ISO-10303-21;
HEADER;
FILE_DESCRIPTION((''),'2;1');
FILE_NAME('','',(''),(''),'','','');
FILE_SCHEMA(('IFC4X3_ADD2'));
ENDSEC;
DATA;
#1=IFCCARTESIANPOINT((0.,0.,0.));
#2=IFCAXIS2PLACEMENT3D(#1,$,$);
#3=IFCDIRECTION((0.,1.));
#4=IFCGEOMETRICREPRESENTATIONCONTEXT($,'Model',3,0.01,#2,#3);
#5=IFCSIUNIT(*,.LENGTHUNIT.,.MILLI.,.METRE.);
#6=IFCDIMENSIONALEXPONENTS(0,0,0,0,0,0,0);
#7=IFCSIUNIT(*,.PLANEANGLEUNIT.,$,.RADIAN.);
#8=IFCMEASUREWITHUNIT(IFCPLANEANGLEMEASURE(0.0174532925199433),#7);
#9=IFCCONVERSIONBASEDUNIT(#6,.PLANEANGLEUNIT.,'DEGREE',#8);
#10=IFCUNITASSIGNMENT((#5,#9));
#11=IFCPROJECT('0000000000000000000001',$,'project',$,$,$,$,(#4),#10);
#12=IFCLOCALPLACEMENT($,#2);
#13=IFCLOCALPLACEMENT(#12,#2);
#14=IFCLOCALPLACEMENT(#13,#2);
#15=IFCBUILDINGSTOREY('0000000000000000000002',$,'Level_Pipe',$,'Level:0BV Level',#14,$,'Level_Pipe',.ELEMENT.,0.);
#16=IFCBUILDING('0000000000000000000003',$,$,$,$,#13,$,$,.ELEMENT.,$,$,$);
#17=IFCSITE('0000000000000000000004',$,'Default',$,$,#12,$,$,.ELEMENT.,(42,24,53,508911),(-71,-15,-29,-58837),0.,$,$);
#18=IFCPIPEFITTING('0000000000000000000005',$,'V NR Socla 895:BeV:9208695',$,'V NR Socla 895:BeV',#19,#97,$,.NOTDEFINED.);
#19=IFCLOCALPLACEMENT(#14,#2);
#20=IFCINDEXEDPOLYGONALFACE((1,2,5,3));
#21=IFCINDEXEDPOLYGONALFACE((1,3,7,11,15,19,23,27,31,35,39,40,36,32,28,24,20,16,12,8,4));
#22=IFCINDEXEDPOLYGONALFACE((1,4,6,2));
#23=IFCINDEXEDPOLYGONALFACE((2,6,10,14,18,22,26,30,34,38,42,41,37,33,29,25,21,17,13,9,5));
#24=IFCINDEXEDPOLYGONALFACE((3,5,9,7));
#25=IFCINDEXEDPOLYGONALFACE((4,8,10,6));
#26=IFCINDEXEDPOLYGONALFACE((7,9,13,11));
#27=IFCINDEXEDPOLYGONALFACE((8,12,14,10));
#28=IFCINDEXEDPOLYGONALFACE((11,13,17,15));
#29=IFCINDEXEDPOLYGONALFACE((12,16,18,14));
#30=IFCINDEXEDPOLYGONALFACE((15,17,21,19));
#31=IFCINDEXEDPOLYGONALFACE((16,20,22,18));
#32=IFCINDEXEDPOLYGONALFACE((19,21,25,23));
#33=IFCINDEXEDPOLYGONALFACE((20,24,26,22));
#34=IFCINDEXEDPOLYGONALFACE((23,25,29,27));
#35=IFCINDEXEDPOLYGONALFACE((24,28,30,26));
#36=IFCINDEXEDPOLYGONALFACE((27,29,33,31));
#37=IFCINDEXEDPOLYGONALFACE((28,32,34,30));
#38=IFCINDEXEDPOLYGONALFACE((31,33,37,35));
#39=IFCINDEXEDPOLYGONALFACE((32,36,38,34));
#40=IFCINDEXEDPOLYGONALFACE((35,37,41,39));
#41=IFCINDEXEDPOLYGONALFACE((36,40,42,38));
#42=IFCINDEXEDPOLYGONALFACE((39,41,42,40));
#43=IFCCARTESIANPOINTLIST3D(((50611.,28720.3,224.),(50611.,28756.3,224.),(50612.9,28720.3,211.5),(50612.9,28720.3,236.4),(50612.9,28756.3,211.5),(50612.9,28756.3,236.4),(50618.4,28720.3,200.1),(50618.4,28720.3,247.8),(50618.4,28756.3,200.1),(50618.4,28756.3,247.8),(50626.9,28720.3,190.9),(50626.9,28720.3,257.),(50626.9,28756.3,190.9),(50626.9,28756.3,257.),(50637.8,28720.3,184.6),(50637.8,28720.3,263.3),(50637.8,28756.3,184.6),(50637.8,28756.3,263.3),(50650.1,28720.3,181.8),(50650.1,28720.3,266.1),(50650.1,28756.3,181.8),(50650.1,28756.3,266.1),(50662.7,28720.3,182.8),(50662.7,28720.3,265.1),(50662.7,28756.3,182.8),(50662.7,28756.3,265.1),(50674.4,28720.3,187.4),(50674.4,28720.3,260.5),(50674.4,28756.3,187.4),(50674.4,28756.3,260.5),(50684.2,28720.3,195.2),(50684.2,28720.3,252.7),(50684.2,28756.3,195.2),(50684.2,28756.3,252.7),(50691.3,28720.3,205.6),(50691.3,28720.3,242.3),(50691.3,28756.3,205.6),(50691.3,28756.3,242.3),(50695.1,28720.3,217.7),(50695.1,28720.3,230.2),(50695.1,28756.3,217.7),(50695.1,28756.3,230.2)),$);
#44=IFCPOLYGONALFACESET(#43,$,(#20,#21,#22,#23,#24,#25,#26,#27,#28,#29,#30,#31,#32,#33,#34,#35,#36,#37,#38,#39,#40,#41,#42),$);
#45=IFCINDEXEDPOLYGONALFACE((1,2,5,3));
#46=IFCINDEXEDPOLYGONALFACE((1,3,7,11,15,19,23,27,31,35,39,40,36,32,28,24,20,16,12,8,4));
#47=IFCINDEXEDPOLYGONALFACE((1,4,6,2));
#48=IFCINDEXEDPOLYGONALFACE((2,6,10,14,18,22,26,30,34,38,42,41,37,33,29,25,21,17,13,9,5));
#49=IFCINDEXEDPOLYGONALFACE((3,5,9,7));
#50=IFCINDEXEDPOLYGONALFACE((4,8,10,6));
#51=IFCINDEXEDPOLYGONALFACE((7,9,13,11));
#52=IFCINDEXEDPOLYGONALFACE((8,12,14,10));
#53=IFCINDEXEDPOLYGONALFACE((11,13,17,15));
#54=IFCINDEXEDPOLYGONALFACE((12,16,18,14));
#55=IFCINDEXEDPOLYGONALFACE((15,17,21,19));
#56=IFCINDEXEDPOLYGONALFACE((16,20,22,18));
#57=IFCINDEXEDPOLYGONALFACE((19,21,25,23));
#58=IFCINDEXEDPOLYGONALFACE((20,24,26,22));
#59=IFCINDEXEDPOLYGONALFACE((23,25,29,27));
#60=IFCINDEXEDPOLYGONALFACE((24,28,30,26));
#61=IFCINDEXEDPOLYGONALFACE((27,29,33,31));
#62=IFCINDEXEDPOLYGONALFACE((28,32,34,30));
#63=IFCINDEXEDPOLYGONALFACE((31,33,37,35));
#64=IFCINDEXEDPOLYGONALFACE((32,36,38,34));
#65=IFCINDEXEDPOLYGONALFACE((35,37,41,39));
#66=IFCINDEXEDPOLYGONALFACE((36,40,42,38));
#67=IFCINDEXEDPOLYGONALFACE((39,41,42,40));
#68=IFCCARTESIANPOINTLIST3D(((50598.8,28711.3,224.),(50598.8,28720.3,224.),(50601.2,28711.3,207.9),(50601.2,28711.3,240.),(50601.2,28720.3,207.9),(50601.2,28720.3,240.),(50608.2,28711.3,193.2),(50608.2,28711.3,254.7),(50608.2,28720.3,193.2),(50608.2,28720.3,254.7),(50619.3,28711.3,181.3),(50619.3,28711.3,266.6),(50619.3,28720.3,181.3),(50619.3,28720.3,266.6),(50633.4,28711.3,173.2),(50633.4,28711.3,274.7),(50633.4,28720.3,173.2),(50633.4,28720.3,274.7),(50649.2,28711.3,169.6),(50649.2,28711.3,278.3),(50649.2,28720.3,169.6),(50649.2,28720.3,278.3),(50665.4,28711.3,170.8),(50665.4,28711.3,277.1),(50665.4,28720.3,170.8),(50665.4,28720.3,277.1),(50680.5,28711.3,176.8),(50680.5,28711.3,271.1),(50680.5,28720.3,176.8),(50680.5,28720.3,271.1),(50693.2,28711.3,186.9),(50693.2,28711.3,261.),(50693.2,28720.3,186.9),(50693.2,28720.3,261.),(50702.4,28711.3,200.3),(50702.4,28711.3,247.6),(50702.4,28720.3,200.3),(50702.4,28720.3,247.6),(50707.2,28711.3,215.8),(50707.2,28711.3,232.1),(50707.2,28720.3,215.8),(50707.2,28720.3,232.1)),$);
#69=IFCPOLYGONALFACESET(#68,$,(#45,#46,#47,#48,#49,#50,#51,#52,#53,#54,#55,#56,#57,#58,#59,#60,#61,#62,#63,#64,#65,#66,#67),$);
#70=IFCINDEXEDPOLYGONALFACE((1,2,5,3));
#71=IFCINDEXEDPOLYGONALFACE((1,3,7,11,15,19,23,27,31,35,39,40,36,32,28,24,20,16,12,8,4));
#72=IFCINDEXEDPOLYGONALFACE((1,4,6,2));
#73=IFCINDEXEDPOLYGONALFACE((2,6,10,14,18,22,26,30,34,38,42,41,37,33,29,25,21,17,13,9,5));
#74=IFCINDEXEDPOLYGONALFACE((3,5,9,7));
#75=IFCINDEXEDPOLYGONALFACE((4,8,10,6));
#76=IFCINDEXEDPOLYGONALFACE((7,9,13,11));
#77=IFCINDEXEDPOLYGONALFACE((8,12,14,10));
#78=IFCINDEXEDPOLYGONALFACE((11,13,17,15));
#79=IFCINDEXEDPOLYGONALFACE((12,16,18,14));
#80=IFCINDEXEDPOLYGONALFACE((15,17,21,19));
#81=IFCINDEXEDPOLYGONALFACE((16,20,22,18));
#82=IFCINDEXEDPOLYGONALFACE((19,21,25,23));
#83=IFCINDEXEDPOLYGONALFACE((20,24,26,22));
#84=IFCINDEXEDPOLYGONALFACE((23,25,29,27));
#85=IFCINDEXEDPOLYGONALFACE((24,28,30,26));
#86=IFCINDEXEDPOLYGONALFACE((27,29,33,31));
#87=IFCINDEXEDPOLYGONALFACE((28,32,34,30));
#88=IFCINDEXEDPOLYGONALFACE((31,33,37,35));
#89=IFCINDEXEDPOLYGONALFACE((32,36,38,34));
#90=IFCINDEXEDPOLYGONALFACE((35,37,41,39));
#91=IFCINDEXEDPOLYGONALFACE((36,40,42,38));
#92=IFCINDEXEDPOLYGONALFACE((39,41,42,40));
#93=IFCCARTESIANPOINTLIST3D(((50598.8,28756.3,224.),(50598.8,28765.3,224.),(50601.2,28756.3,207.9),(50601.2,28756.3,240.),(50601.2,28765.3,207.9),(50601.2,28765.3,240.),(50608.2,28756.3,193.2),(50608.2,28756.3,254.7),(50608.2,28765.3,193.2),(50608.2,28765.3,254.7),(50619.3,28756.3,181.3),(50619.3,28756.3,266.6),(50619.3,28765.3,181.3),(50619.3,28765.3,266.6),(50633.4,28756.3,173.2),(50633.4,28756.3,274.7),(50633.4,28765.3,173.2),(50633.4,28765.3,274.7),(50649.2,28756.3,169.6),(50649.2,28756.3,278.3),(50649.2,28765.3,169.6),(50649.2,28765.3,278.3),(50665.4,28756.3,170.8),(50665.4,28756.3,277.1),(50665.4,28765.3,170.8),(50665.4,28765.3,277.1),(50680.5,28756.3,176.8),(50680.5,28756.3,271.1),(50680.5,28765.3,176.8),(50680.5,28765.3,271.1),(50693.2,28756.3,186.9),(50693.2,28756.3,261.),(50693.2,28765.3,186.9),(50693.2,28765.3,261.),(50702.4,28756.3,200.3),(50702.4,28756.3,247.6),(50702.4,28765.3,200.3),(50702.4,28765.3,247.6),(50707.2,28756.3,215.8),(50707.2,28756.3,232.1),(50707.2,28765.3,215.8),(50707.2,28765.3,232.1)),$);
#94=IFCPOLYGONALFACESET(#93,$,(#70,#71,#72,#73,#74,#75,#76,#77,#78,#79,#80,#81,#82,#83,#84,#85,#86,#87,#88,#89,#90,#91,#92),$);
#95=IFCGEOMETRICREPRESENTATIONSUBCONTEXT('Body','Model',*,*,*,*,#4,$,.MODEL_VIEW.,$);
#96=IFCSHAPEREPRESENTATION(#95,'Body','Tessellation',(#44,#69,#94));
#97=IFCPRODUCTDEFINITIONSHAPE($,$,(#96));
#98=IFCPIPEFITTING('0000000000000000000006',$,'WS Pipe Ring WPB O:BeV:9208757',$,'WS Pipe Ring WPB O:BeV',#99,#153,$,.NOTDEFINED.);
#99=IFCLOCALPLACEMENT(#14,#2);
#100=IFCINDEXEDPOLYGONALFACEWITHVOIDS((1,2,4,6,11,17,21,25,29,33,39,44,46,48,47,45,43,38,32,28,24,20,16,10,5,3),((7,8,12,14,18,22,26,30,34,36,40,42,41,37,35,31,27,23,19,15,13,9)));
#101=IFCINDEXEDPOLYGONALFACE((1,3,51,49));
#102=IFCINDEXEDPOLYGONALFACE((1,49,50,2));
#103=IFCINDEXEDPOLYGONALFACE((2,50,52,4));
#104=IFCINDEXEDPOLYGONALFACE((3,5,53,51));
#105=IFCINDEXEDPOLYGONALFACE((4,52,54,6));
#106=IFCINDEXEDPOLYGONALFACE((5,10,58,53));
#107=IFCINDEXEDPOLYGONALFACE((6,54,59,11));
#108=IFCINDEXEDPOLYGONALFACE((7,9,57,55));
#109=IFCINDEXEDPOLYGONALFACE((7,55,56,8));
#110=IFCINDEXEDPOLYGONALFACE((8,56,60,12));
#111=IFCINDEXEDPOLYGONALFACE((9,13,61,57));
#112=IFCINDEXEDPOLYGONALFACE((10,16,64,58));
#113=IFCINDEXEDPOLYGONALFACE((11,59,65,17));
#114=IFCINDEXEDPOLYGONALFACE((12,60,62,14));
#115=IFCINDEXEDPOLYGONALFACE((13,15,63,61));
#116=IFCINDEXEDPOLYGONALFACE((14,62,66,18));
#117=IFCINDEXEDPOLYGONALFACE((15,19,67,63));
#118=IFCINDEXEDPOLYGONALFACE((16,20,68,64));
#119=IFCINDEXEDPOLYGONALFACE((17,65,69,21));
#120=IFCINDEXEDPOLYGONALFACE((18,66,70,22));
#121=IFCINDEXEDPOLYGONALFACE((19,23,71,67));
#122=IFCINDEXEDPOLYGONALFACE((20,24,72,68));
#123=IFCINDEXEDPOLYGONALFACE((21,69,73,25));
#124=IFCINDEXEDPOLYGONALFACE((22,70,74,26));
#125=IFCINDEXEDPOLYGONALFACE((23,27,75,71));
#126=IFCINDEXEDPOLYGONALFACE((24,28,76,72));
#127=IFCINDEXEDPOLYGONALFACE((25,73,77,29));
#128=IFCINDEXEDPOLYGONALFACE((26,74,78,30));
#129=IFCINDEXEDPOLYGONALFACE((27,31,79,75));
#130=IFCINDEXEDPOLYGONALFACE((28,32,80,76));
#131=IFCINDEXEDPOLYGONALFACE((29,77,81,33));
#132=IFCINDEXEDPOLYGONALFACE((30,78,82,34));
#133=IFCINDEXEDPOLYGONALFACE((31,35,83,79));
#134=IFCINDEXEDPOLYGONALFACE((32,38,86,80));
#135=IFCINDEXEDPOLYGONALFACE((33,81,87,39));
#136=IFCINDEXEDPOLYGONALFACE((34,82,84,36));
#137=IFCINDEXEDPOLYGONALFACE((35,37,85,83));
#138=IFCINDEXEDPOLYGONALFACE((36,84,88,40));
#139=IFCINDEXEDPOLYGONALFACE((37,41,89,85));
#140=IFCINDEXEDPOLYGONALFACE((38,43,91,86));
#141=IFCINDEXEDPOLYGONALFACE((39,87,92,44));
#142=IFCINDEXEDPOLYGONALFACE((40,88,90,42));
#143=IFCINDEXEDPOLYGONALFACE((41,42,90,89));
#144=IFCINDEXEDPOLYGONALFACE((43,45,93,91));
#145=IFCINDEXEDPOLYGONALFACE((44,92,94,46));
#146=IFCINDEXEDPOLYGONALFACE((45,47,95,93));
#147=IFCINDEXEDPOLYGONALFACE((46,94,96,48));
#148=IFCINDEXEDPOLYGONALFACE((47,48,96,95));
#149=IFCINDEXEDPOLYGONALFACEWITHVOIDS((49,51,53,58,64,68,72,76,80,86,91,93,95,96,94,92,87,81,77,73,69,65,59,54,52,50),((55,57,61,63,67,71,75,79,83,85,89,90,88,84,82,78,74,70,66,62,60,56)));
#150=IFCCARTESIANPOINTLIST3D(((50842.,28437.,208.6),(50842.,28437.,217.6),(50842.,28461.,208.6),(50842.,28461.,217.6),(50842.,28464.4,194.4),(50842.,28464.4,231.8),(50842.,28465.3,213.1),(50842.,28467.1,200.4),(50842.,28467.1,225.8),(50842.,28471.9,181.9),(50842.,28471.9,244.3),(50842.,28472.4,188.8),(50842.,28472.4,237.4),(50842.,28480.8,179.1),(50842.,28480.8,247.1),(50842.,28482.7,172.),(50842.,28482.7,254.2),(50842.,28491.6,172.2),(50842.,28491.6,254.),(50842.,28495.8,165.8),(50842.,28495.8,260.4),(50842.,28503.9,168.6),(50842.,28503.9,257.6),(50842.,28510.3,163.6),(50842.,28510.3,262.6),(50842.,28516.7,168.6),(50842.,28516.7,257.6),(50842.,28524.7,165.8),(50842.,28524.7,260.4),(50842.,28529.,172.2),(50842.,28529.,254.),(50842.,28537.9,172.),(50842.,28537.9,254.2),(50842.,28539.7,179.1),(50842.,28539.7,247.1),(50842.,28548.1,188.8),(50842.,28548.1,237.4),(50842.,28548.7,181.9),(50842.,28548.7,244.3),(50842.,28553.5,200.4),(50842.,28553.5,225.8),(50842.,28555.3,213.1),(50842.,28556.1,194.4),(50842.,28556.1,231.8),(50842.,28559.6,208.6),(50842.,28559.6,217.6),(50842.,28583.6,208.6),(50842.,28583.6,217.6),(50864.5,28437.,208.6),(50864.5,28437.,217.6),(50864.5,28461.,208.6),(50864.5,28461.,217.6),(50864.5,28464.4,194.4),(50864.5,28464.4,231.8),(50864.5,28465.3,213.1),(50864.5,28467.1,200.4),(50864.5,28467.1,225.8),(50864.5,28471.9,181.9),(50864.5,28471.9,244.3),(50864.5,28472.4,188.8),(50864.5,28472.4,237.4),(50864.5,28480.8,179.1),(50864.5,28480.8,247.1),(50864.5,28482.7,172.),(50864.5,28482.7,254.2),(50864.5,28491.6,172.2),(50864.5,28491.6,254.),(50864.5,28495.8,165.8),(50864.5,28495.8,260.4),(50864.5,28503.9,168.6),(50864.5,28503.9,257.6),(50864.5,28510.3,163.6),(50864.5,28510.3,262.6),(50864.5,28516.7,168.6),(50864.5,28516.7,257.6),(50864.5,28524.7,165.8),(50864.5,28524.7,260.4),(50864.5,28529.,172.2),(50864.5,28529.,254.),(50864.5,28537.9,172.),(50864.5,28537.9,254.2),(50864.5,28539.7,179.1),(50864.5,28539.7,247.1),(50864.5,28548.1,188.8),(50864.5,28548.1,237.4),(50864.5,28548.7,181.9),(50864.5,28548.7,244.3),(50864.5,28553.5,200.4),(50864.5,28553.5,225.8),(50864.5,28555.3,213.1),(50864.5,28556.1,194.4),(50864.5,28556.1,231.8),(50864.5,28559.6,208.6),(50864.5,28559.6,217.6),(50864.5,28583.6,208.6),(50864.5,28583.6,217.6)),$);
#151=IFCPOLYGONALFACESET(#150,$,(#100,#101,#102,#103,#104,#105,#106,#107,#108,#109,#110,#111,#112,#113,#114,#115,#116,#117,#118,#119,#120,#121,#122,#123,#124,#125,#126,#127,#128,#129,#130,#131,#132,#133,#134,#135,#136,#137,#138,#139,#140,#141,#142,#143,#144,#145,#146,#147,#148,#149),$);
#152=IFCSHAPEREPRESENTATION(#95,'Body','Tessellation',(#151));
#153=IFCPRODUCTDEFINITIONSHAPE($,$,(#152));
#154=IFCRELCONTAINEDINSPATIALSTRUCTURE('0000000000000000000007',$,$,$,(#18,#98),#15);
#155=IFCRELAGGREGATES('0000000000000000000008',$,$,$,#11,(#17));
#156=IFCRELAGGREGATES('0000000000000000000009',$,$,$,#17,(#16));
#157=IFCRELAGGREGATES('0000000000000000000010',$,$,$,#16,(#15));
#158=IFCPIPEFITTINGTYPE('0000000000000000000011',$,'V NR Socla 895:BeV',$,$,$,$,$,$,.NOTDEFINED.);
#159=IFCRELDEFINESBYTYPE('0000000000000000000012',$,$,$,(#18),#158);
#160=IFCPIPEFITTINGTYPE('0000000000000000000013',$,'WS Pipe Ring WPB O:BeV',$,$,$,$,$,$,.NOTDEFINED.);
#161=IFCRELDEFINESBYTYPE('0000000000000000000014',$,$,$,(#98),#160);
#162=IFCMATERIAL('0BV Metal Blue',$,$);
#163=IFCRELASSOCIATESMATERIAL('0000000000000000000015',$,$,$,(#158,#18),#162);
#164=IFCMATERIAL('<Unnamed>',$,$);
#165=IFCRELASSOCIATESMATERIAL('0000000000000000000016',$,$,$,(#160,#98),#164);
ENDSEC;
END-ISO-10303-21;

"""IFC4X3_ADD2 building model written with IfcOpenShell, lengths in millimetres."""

from ifc_helpers import new_model, entity, si_unit, converted_unit, direction, frame, frame_2d, origin, origin_2d_with_axis, place, context, subcontext, project, spatial, polyline, circle_curve, parameter, trimmed, segment, composite_curve, circle, outline, extrude, source, transform, mapped, material, type_object, type_shapes, element, save


model = new_model("IFC4X3_ADD2")

# Units and contexts
model_context = context("Model", 3, precision=0.01, world=origin(), true_north=direction((0.0, 1.0)))
body_context = subcontext(model_context, "Body", "Model", "MODEL_VIEW")
ifc_project = project(units=[si_unit("LENGTHUNIT", "METRE", prefix="MILLI"), converted_unit("PLANEANGLEUNIT", "DEGREE", entity("IfcPlaneAngleMeasure", 0.0174532925199433), si_unit("PLANEANGLEUNIT", "RADIAN"), dimensions=[0, 0, 0, 0, 0, 0, 0])], contexts=[model_context])

# Site, building, storey
site_placement = place(None, origin())
site = spatial("IfcSite", under=ifc_project, at=site_placement, Name="Default", CompositionType="ELEMENT", RefLatitude=(42, 24, 53, 508911), RefLongitude=(-71, -15, -29, -58837), RefElevation=0.0)
building_placement = place(site_placement, origin())
building = spatial("IfcBuilding", under=site, at=building_placement, CompositionType="ELEMENT")
storey_placement = place(building_placement, origin())
storey = spatial("IfcBuildingStorey", under=building, at=storey_placement, Name="Level_Pipe", ObjectType="Level:0BV Level", LongName="Level_Pipe", CompositionType="ELEMENT", Elevation=0.0)

# Pipe fittings
ifc_material_1 = material(Name="0BV Metal Blue")
pipe_fitting_type_1 = type_object("IfcPipeFittingType", Name="V NR Socla 895:BeV", PredefinedType="NOTDEFINED", material=ifc_material_1)
shared_shape_1 = source(origin(), body_context, "Body", "SweptSolid", [
    extrude(circle(Radius=42.2, at=frame_2d((0.0, 0.0), x_axis=(1.0, 0.0))), frame((-18.0, 0.0, 0.0), z_axis=(1.0, 0.0, 0.0), x_axis=(0.0, 1.0, 0.0)), (0.0, 0.0, 1.0), 36.0),
    extrude(circle(Radius=54.5, at=frame_2d((0.0, 0.0), x_axis=(1.0, 0.0))), frame((18.0, 0.0, 0.0), z_axis=(1.0, 0.0, 0.0), x_axis=(0.0, 1.0, 0.0)), (0.0, 0.0, 1.0), 9.0),
    extrude(circle(Radius=54.5, at=frame_2d((0.0, 0.0), x_axis=(1.0, 0.0))), frame((-27.0, 0.0, 0.0), z_axis=(1.0, 0.0, 0.0), x_axis=(0.0, 1.0, 0.0)), (0.0, 0.0, 1.0), 9.0),
])
type_shapes(pipe_fitting_type_1, [shared_shape_1])
pipe_fitting_1_placement = place(storey_placement, frame((50653.3, 28738.3, 223.9), z_axis=(0.0, 0.0, -1.0), x_axis=(0.0, -1.0, 0.0)))
element("IfcPipeFitting", 1, at=pipe_fitting_1_placement, inside=storey, type_object=pipe_fitting_type_1, material=ifc_material_1, Name="V NR Socla 895:BeV:9208695", ObjectType="V NR Socla 895:BeV", PredefinedType="NOTDEFINED", context=body_context, shape_type="MappedRepresentation", body=[
    mapped(shared_shape_1, transform((0.0, 0.0, 0.0), scale=1.0)),
])
ifc_material_2 = material(Name="<Unnamed>")
pipe_fitting_type_2 = type_object("IfcPipeFittingType", Name="WS Pipe Ring WPB O:BeV", PredefinedType="NOTDEFINED", material=ifc_material_2)
shared_shape_2 = source(origin(), body_context, "Body", "SweptSolid", [
    extrude(outline(composite_curve([segment(trimmed(circle_curve(origin_2d_with_axis(), 49.5), [parameter(185.215909)], [parameter(354.784091)], True, "PARAMETER"), True, "CONTINUOUS"), segment(polyline([(49.3, -4.5), (73.3, -4.5)]), True, "CONTINUOUS"), segment(polyline([(73.3, -4.5), (73.3, 4.5)]), True, "CONTINUOUS"), segment(polyline([(73.3, 4.5), (49.3, 4.5)]), True, "CONTINUOUS"), segment(trimmed(circle_curve(origin_2d_with_axis(), 49.5), [parameter(5.215909)], [parameter(174.784091)], True, "PARAMETER"), True, "CONTINUOUS"), segment(polyline([(-49.3, 4.5), (-73.3, 4.5)]), True, "CONTINUOUS"), segment(polyline([(-73.3, 4.5), (-73.3, -4.5)]), True, "CONTINUOUS"), segment(polyline([(-73.3, -4.5), (-49.3, -4.5)]), True, "CONTINUOUS")], self_intersect=False), holes=[composite_curve([segment(trimmed(circle_curve(origin_2d_with_axis(), 45.0), [parameter(0.0)], [parameter(180.0)], True, "PARAMETER"), False, "CONTINUOUS"), segment(trimmed(circle_curve(origin_2d_with_axis(), 45.0), [parameter(180.0)], [parameter(360.0)], True, "PARAMETER"), False, "CONTINUOUS")], self_intersect=False)]), frame((0.0, -11.2, 0.0), z_axis=(0.0, 1.0, 0.0), x_axis=(1.0, 0.0, 0.0)), (0.0, 0.0, 1.0), 22.5),
])
type_shapes(pipe_fitting_type_2, [shared_shape_2])
pipe_fitting_2_placement = place(storey_placement, frame((50853.3, 28510.3, 213.1), z_axis=(0.0, 0.0, 1.0), x_axis=(0.0, 1.0, 0.0)))
element("IfcPipeFitting", 2, at=pipe_fitting_2_placement, inside=storey, type_object=pipe_fitting_type_2, material=ifc_material_2, Name="WS Pipe Ring WPB O:BeV:9208757", ObjectType="WS Pipe Ring WPB O:BeV", PredefinedType="NOTDEFINED", context=body_context, shape_type="MappedRepresentation", body=[
    mapped(shared_shape_2, transform((0.0, 0.0, 0.0), scale=1.0)),
])

save(model, "model.ifc")
